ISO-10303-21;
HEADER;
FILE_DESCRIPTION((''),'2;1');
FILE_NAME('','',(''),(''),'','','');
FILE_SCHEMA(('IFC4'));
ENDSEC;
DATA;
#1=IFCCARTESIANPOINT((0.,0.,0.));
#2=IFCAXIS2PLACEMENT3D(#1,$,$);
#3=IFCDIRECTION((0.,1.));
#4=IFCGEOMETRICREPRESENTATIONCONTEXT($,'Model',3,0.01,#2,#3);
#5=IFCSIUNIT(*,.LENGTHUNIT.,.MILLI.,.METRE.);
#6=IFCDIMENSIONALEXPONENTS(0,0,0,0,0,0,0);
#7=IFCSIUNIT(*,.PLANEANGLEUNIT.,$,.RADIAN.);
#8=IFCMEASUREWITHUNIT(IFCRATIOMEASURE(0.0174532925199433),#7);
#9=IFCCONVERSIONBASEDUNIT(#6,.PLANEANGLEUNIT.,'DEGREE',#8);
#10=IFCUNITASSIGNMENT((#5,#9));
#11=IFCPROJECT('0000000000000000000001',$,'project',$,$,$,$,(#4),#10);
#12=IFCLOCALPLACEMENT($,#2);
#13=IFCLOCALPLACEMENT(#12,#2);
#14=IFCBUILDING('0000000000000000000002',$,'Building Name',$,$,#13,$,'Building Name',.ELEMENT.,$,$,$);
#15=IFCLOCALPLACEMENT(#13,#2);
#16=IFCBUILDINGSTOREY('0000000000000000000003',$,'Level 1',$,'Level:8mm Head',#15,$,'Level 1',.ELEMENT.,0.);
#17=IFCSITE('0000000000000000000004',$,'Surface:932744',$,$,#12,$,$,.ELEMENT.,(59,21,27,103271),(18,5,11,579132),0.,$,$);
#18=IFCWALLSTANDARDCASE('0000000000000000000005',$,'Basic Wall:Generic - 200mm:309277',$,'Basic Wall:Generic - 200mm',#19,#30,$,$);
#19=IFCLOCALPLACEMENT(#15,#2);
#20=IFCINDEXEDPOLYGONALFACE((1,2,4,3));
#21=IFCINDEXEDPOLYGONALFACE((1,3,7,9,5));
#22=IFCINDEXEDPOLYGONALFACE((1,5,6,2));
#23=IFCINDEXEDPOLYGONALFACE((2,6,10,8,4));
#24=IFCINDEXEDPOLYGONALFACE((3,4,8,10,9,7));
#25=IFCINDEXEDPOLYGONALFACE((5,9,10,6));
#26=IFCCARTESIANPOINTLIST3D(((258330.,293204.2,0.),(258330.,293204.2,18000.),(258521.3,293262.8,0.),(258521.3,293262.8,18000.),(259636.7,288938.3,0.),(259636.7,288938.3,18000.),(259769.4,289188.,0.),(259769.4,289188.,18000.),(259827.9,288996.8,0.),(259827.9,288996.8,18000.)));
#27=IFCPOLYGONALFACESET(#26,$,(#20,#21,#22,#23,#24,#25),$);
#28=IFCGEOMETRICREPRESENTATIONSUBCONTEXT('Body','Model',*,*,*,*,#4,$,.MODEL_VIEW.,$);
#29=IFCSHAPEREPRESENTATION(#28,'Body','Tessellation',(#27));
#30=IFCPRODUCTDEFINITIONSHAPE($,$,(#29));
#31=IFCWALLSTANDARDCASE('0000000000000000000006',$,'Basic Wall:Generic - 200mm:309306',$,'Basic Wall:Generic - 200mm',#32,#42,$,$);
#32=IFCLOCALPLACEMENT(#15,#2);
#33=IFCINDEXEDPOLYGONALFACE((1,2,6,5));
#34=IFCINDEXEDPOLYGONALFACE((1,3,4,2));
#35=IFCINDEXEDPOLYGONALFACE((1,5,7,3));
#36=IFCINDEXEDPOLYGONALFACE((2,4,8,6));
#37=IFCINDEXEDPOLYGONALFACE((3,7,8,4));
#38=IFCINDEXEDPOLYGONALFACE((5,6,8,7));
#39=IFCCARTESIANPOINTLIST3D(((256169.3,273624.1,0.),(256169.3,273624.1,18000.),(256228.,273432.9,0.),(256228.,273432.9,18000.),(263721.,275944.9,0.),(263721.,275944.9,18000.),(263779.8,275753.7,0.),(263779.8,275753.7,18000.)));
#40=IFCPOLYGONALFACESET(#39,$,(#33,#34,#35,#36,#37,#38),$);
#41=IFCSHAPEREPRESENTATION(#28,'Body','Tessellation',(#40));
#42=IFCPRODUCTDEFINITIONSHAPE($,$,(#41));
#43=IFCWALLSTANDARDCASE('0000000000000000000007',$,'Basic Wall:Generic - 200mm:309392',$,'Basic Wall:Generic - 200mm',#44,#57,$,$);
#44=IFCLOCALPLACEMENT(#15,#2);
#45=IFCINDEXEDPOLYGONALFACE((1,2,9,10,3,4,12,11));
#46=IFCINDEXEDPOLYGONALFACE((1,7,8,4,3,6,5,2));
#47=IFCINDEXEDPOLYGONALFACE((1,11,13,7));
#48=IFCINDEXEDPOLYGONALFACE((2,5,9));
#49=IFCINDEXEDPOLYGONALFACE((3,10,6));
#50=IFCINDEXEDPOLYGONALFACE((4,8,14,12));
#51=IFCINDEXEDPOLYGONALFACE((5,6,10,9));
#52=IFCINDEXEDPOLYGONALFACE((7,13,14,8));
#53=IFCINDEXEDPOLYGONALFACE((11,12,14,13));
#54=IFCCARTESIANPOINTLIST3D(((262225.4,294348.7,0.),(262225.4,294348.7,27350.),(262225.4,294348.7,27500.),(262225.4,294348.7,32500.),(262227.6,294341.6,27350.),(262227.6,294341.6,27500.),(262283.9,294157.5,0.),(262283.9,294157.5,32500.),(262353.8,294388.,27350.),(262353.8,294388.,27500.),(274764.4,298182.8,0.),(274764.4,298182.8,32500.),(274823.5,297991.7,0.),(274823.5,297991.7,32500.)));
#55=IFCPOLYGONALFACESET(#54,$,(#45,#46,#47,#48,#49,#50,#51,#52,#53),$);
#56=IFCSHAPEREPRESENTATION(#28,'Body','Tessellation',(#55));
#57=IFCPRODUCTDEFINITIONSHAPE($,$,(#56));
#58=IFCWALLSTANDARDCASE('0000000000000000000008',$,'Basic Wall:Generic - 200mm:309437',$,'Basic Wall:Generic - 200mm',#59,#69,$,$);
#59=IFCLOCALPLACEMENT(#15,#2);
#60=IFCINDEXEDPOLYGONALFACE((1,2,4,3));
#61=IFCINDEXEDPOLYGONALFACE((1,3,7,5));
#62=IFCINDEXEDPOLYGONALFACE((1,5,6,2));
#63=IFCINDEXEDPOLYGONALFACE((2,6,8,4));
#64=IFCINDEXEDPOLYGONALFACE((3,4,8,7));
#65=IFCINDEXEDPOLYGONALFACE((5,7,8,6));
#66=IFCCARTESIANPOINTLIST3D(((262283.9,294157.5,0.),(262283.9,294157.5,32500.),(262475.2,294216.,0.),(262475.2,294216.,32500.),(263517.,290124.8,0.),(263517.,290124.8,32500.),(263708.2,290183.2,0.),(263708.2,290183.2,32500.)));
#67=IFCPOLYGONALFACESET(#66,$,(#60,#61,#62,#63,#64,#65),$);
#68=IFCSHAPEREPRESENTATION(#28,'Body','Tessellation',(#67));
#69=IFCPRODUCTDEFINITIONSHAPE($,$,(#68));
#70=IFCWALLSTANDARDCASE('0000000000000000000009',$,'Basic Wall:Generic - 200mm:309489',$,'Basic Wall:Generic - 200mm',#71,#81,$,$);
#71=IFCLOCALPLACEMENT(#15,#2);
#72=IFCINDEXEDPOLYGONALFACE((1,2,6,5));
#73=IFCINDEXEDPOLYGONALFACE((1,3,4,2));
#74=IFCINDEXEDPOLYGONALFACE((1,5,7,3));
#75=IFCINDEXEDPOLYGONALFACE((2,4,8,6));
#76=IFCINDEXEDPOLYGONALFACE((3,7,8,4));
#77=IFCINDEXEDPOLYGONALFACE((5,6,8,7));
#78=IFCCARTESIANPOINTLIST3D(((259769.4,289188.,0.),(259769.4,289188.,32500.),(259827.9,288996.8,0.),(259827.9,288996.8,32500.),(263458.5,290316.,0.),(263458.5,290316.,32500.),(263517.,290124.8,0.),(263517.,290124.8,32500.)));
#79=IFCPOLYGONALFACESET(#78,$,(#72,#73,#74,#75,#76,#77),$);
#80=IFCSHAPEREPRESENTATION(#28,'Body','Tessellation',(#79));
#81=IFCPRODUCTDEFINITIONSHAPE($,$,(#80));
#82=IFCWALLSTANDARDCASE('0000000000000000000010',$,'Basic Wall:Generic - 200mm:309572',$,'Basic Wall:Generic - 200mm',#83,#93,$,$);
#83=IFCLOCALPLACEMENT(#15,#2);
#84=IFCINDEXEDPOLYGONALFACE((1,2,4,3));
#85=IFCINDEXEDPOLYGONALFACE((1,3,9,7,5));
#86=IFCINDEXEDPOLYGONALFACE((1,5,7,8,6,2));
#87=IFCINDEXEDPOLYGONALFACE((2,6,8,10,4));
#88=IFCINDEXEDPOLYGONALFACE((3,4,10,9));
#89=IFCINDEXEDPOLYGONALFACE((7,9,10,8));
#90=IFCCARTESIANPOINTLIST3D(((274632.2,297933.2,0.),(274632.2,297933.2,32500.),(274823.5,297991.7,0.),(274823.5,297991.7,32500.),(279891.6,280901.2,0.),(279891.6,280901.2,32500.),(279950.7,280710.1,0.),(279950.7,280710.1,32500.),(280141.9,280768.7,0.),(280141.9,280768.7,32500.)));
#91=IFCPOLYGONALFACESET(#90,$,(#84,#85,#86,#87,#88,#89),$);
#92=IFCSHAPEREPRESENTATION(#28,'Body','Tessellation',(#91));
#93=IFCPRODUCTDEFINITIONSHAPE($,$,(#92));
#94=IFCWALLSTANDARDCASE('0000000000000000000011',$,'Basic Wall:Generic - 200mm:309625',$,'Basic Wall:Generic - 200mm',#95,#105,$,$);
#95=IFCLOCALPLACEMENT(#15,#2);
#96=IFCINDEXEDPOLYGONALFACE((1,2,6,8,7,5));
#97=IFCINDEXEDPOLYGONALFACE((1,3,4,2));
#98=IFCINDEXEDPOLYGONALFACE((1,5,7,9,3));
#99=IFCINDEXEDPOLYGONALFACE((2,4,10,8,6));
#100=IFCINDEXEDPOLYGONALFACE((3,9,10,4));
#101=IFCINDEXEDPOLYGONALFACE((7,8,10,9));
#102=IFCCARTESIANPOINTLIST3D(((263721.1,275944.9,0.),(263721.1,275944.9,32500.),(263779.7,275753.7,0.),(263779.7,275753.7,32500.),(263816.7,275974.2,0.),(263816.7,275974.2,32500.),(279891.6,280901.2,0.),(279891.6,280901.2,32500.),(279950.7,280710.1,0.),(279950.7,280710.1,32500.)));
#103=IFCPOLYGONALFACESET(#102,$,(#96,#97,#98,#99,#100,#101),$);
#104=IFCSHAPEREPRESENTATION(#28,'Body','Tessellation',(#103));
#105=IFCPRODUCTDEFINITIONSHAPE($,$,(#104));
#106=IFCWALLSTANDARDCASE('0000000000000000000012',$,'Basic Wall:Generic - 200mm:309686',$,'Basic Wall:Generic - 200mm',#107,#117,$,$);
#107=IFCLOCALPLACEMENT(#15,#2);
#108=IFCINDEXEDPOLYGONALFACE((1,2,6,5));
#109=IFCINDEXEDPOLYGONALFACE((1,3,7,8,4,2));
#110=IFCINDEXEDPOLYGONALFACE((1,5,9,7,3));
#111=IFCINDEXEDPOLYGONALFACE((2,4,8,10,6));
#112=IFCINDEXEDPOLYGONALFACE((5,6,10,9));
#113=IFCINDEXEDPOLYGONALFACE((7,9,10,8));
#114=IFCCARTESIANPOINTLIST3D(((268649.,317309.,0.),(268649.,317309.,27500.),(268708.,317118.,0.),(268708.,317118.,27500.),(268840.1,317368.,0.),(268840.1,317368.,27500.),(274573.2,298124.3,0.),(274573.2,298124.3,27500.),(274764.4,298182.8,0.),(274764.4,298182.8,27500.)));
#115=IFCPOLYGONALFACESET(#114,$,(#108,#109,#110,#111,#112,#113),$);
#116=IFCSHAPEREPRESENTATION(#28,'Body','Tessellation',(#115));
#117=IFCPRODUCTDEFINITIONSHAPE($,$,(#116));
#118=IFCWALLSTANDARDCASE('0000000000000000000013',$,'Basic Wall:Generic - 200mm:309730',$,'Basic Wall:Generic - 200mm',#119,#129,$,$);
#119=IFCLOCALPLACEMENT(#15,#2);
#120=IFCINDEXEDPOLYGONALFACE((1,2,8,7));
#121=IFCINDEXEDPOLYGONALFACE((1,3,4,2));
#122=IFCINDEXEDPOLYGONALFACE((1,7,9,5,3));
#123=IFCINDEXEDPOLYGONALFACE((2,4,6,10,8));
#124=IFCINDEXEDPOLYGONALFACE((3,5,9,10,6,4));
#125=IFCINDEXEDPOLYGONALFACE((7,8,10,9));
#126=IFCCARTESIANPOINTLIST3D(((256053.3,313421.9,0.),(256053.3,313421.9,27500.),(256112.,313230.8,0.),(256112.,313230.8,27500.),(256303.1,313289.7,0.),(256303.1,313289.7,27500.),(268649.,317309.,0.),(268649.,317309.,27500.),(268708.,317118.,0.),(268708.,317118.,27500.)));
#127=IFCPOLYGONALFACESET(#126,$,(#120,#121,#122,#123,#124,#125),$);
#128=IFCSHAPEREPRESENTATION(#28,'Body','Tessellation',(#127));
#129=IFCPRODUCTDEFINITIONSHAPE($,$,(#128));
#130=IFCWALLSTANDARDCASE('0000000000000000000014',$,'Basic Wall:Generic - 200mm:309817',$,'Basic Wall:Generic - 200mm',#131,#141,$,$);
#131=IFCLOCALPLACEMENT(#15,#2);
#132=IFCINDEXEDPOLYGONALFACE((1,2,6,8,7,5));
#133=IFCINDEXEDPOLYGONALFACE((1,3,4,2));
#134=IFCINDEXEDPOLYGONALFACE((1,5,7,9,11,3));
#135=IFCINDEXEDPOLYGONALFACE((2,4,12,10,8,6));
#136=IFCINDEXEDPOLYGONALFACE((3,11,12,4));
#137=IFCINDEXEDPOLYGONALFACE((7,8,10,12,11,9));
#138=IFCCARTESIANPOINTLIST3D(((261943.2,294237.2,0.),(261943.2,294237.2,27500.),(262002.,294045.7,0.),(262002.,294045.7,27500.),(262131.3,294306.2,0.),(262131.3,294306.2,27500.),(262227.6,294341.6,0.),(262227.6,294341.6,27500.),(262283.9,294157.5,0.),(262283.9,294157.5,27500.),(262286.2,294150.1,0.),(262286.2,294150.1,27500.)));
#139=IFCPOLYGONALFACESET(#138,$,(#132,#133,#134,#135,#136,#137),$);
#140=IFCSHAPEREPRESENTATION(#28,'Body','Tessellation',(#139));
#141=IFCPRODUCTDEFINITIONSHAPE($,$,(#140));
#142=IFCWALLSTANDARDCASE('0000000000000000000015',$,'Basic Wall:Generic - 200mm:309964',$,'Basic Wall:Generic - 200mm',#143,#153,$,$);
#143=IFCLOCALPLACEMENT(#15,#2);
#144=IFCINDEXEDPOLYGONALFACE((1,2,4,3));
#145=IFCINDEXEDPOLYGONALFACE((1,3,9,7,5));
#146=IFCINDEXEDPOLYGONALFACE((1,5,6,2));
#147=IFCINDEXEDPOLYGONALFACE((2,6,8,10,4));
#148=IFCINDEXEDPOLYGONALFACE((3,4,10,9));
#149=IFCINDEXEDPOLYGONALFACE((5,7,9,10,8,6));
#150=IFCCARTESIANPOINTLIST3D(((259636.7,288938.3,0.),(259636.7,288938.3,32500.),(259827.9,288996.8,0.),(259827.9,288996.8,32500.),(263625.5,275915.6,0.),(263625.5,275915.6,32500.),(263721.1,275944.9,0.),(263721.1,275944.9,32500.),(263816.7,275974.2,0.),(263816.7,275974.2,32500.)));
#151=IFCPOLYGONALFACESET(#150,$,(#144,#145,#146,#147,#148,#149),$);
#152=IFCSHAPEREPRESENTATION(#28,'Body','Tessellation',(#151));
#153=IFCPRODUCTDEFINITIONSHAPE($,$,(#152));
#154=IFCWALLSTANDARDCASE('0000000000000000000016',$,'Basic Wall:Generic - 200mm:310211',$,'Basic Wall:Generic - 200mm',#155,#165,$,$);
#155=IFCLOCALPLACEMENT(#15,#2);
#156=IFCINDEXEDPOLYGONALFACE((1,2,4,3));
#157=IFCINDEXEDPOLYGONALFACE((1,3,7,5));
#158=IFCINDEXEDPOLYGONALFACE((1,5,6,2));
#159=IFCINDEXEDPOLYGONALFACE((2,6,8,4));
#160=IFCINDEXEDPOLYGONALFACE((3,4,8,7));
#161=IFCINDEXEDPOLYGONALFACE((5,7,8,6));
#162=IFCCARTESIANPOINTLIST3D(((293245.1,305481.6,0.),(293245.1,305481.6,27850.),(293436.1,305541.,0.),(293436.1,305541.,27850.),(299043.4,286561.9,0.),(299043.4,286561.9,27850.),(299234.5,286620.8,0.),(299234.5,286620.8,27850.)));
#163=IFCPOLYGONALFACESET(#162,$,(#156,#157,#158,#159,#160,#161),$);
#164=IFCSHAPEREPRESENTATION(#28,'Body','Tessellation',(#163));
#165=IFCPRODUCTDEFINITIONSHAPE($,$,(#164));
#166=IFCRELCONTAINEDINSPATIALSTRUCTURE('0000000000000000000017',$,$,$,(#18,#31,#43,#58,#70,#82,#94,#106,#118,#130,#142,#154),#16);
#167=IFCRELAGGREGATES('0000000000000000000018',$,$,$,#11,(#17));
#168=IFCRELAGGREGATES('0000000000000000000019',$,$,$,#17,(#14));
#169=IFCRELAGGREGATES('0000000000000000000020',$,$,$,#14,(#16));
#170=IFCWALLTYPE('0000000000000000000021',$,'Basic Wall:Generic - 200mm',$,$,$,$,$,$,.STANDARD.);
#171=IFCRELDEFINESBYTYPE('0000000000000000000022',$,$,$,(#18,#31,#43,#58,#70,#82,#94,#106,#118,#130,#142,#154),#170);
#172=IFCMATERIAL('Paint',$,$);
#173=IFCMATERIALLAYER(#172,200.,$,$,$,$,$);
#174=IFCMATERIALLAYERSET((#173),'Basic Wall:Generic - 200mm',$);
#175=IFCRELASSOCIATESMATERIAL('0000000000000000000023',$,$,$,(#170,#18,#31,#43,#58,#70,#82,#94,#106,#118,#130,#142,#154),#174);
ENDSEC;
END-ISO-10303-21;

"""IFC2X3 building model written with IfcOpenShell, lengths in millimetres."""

from ifc_helpers import new_model, entity, si_unit, converted_unit, direction, frame, frame_2d, origin, place, context, subcontext, project, spatial, polyline, rectangle, outline, extrude, clip, bounded_halfspace, material, layer, layer_set, layer_usage, type_object, element, save


model = new_model("IFC2X3")

# Units and contexts
model_context = context("Model", 3, precision=0.01, world=origin(), true_north=direction((0.0, 1.0)))
body_context = subcontext(model_context, "Body", "Model", "MODEL_VIEW")
ifc_project = project(units=[si_unit("LENGTHUNIT", "METRE", prefix="MILLI"), converted_unit("PLANEANGLEUNIT", "DEGREE", entity("IfcRatioMeasure", 0.0174532925199433), si_unit("PLANEANGLEUNIT", "RADIAN"), dimensions=[0, 0, 0, 0, 0, 0, 0])], contexts=[model_context])

# Site, building, storey
site_placement = place(None, origin())
site = spatial("IfcSite", under=ifc_project, at=site_placement, Name="Surface:932744", CompositionType="ELEMENT", RefLatitude=(59, 21, 27, 103271), RefLongitude=(18, 5, 11, 579132), RefElevation=0.0)
building_placement = place(site_placement, origin())
building = spatial("IfcBuilding", under=site, at=building_placement, Name="Building Name", LongName="Building Name", CompositionType="ELEMENT")
storey_placement = place(building_placement, origin())
storey = spatial("IfcBuildingStorey", under=building, at=storey_placement, Name="Level 1", ObjectType="Level:8mm Head", LongName="Level 1", CompositionType="ELEMENT", Elevation=0.0)

# Walls
ifc_material_1 = material(Name="Paint")
ifc_layer_1 = layer(ifc_material_1, 200.0)
ifc_layer_set_1 = layer_set([ifc_layer_1], Name="Basic Wall:Generic - 200mm")
ifc_layer_usage_1 = layer_usage(ifc_layer_set_1, "AXIS2", "NEGATIVE", 100.0)
wall_type_1 = type_object("IfcWallType", Name="Basic Wall:Generic - 200mm", PredefinedType="STANDARD", material=ifc_layer_set_1)
wall_1_placement = place(storey_placement, frame((258425.7, 293233.5, 0.0), z_axis=(0.0, 0.0, 1.0), x_axis=(0.292868, -0.956153, 0.0)))
element("IfcWallStandardCase", 1, at=wall_1_placement, inside=storey, type_object=wall_type_1, material=ifc_layer_usage_1, Name="Basic Wall:Generic - 200mm:309277", ObjectType="Basic Wall:Generic - 200mm", context=body_context, shape_type="SweptSolid", body=[
    extrude(outline(polyline([(4461.6, -100.0), (4461.6, 100.0), (4261.6, 100.0), (0.0, 100.0), (0.0, -100.0), (4461.6, -100.0)])), origin(), (0.0, 0.0, 1.0), 18000.0),
])
ifc_layer_usage_2 = layer_usage(ifc_layer_set_1, "AXIS2", "NEGATIVE", 100.0)
wall_2_placement = place(storey_placement, frame((263750.4, 275849.3, 0.0), z_axis=(0.0, 0.0, 1.0), x_axis=(-0.95588, -0.293758, 0.0)))
element("IfcWallStandardCase", 2, at=wall_2_placement, inside=storey, type_object=wall_type_1, material=ifc_layer_usage_2, Name="Basic Wall:Generic - 200mm:309306", ObjectType="Basic Wall:Generic - 200mm", context=body_context, shape_type="SweptSolid", body=[
    extrude(outline(polyline([(7900.3, -100.0), (7900.3, 100.0), (0.0, 100.0), (0.0, -100.0), (7900.3, -100.0)])), origin(), (0.0, 0.0, 1.0), 18000.0),
])
ifc_layer_usage_3 = layer_usage(ifc_layer_set_1, "AXIS2", "NEGATIVE", 100.0)
wall_3_placement = place(storey_placement, frame((274794.2, 298087.3, 0.0), z_axis=(0.0, 0.0, 1.0), x_axis=(-0.956295, -0.292403, 0.0)))
element("IfcWallStandardCase", 3, at=wall_3_placement, inside=storey, type_object=wall_type_1, material=ifc_layer_usage_3, Name="Basic Wall:Generic - 200mm:309392", ObjectType="Basic Wall:Generic - 200mm", context=body_context, shape_type="Clipping", body=[
    clip(extrude(outline(polyline([(13112.7, -100.0), (13112.7, -92.6), (13112.7, 100.0), (12912.7, 100.0), (200.0, 100.0), (0.0, 100.0), (0.6, -100.0), (200.6, -100.0), (13112.7, -100.0)])), origin(), (0.0, 0.0, 1.0), 32500.0), bounded_halfspace(frame((12978.4, -100.0, 27350.0), z_axis=(-0.055214, 0.998475, 0.0), x_axis=(0.0, 0.0, 1.0)), True, frame((12978.4, -100.0, 27350.0), z_axis=(-0.055214, 0.998475, 0.0), x_axis=(0.0, 0.0, 1.0)), polyline([(0.0, 0.0), (150.0, 0.0), (150.0, 134.5), (0.0, 134.5), (0.0, 0.0)]))),
])
ifc_layer_usage_4 = layer_usage(ifc_layer_set_1, "AXIS2", "NEGATIVE", 100.0)
wall_4_placement = place(storey_placement, frame((262379.5, 294186.7, 0.0), z_axis=(0.0, 0.0, 1.0), x_axis=(0.292403, -0.956295, 0.0)))
element("IfcWallStandardCase", 4, at=wall_4_placement, inside=storey, type_object=wall_type_1, material=ifc_layer_usage_4, Name="Basic Wall:Generic - 200mm:309437", ObjectType="Basic Wall:Generic - 200mm", context=body_context, shape_type="SweptSolid", body=[
    extrude(rectangle(XDim=4217.0, YDim=200.0, at=frame_2d((2108.5, 0.0), x_axis=(-1.0, 0.0))), origin(), (0.0, 0.0, 1.0), 32500.0),
])
ifc_layer_usage_5 = layer_usage(ifc_layer_set_1, "AXIS2", "NEGATIVE", 100.0)
wall_5_placement = place(storey_placement, frame((263487.7, 290220.4, 0.0), z_axis=(0.0, 0.0, 1.0), x_axis=(-0.956295, -0.292403, 0.0)))
element("IfcWallStandardCase", 5, at=wall_5_placement, inside=storey, type_object=wall_type_1, material=ifc_layer_usage_5, Name="Basic Wall:Generic - 200mm:309489", ObjectType="Basic Wall:Generic - 200mm", context=body_context, shape_type="SweptSolid", body=[
    extrude(outline(polyline([(3857.7, -100.0), (3857.6, 100.0), (0.0, 100.0), (0.0, -100.0), (3857.7, -100.0)])), origin(), (0.0, 0.0, 1.0), 32500.0),
])
ifc_layer_usage_6 = layer_usage(ifc_layer_set_1, "AXIS2", "NEGATIVE", 100.0)
wall_6_placement = place(storey_placement, frame((274727.7, 297962.7, 0.0), z_axis=(0.0, 0.0, 1.0), x_axis=(0.295051, -0.955481, 0.0)))
element("IfcWallStandardCase", 6, at=wall_6_placement, inside=storey, type_object=wall_type_1, material=ifc_layer_usage_6, Name="Basic Wall:Generic - 200mm:309572", ObjectType="Basic Wall:Generic - 200mm", context=body_context, shape_type="SweptSolid", body=[
    extrude(outline(polyline([(18025.5, -100.0), (18025.9, 100.0), (0.6, 100.0), (0.0, -100.0), (17825.5, -100.0), (18025.5, -100.0)])), origin(), (0.0, 0.0, 1.0), 32500.0),
])
ifc_layer_usage_7 = layer_usage(ifc_layer_set_1, "AXIS2", "NEGATIVE", 100.0)
wall_7_placement = place(storey_placement, frame((279921.3, 280805.7, 0.0), z_axis=(0.0, 0.0, 1.0), x_axis=(-0.956099, -0.293045, 0.0)))
element("IfcWallStandardCase", 7, at=wall_7_placement, inside=storey, type_object=wall_type_1, material=ifc_layer_usage_7, Name="Basic Wall:Generic - 200mm:309625", ObjectType="Basic Wall:Generic - 200mm", context=body_context, shape_type="SweptSolid", body=[
    extrude(outline(polyline([(16913.5, -100.0), (16913.5, 100.0), (0.0, 100.0), (0.4, -100.0), (16813.5, -100.0), (16913.5, -100.0)])), origin(), (0.0, 0.0, 1.0), 32500.0),
])
ifc_layer_usage_8 = layer_usage(ifc_layer_set_1, "AXIS2", "NEGATIVE", 100.0)
wall_8_placement = place(storey_placement, frame((268744.5, 317338.6, 0.0), z_axis=(0.0, 0.0, 1.0), x_axis=(0.295051, -0.955481, 0.0)))
element("IfcWallStandardCase", 8, at=wall_8_placement, inside=storey, type_object=wall_type_1, material=ifc_layer_usage_8, Name="Basic Wall:Generic - 200mm:309686", ObjectType="Basic Wall:Generic - 200mm", context=body_context, shape_type="SweptSolid", body=[
    extrude(outline(polyline([(20078.7, -100.0), (20079.2, 100.0), (0.0, 100.0), (0.0, -100.0), (200.0, -100.0), (20078.7, -100.0)])), origin(), (0.0, 0.0, 1.0), 27500.0),
])
ifc_layer_usage_9 = layer_usage(ifc_layer_set_1, "AXIS2", "NEGATIVE", 100.0)
wall_9_placement = place(storey_placement, frame((268678.5, 317213.5, 0.0), z_axis=(0.0, 0.0, 1.0), x_axis=(-0.955533, -0.294884, 0.0)))
element("IfcWallStandardCase", 9, at=wall_9_placement, inside=storey, type_object=wall_type_1, material=ifc_layer_usage_9, Name="Basic Wall:Generic - 200mm:309730", ObjectType="Basic Wall:Generic - 200mm", context=body_context, shape_type="SweptSolid", body=[
    extrude(outline(polyline([(13181.8, -100.0), (13182.1, 100.0), (12982.1, 100.0), (0.0, 100.0), (0.0, -100.0), (13181.8, -100.0)])), origin(), (0.0, 0.0, 1.0), 27500.0),
])
ifc_layer_usage_10 = layer_usage(ifc_layer_set_1, "AXIS2", "NEGATIVE", 100.0)
wall_10_placement = place(storey_placement, frame((261967.5, 294139.6, 0.0), z_axis=(0.0, 0.0, 1.0), x_axis=(0.938691, 0.344759, 0.0)))
element("IfcWallStandardCase", 10, at=wall_10_placement, inside=storey, type_object=wall_type_1, material=ifc_layer_usage_10, Name="Basic Wall:Generic - 200mm:309817", ObjectType="Basic Wall:Generic - 200mm", context=body_context, shape_type="SweptSolid", body=[
    extrude(outline(polyline([(302.7, -100.0), (303.1, -92.3), (313.7, 100.0), (211.1, 100.0), (10.8, 100.0), (0.0, -100.0), (302.7, -100.0)])), origin(), (0.0, 0.0, 1.0), 27500.0),
])
ifc_layer_usage_11 = layer_usage(ifc_layer_set_1, "AXIS2", "NEGATIVE", 100.0)
wall_11_placement = place(storey_placement, frame((259732.3, 288967.6, 0.0), z_axis=(0.0, 0.0, 1.0), x_axis=(0.292868, -0.956153, 0.0)))
element("IfcWallStandardCase", 11, at=wall_11_placement, inside=storey, type_object=wall_type_1, material=ifc_layer_usage_11, Name="Basic Wall:Generic - 200mm:309964", ObjectType="Basic Wall:Generic - 200mm", context=body_context, shape_type="SweptSolid", body=[
    extrude(outline(polyline([(13619.9, -100.0), (13619.8, 0.0), (13619.8, 100.0), (0.1, 100.0), (0.0, -100.0), (13619.9, -100.0)])), origin(), (0.0, 0.0, 1.0), 32500.0),
])
ifc_layer_usage_12 = layer_usage(ifc_layer_set_1, "AXIS2", "NEGATIVE", 100.0)
wall_12_placement = place(storey_placement, frame((299139.0, 286591.2, 0.0), z_axis=(0.0, 0.0, 1.0), x_axis=(-0.293014, 0.956108, 0.0)))
element("IfcWallStandardCase", 12, at=wall_12_placement, inside=storey, type_object=wall_type_1, material=ifc_layer_usage_12, Name="Basic Wall:Generic - 200mm:310211", ObjectType="Basic Wall:Generic - 200mm", context=body_context, shape_type="Clipping", body=[
    clip(extrude(outline(polyline([(19789.1, -100.0), (19788.2, 100.0), (0.0, 100.0), (0.2, -100.0), (200.2, -100.0), (19589.0, -100.0), (19789.1, -100.0)])), origin(), (0.0, 0.0, 1.0), 27850.0), bounded_halfspace(frame((0.2, -100.0, 27850.0), z_axis=(0.0, 0.0, -1.0), x_axis=(0.001452, -0.999999, 0.0)), True, frame((0.2, -100.0, 27850.0), z_axis=(0.0, 0.0, -1.0), x_axis=(0.001452, -0.999999, 0.0)), polyline([(0.0, 0.0), (-200.0, -0.1), (-171.3, -19788.2), (28.7, -19788.8), (28.5, -19588.8), (0.3, -200.0), (0.0, 0.0)]))),
])

save(model, "model.ifc")
